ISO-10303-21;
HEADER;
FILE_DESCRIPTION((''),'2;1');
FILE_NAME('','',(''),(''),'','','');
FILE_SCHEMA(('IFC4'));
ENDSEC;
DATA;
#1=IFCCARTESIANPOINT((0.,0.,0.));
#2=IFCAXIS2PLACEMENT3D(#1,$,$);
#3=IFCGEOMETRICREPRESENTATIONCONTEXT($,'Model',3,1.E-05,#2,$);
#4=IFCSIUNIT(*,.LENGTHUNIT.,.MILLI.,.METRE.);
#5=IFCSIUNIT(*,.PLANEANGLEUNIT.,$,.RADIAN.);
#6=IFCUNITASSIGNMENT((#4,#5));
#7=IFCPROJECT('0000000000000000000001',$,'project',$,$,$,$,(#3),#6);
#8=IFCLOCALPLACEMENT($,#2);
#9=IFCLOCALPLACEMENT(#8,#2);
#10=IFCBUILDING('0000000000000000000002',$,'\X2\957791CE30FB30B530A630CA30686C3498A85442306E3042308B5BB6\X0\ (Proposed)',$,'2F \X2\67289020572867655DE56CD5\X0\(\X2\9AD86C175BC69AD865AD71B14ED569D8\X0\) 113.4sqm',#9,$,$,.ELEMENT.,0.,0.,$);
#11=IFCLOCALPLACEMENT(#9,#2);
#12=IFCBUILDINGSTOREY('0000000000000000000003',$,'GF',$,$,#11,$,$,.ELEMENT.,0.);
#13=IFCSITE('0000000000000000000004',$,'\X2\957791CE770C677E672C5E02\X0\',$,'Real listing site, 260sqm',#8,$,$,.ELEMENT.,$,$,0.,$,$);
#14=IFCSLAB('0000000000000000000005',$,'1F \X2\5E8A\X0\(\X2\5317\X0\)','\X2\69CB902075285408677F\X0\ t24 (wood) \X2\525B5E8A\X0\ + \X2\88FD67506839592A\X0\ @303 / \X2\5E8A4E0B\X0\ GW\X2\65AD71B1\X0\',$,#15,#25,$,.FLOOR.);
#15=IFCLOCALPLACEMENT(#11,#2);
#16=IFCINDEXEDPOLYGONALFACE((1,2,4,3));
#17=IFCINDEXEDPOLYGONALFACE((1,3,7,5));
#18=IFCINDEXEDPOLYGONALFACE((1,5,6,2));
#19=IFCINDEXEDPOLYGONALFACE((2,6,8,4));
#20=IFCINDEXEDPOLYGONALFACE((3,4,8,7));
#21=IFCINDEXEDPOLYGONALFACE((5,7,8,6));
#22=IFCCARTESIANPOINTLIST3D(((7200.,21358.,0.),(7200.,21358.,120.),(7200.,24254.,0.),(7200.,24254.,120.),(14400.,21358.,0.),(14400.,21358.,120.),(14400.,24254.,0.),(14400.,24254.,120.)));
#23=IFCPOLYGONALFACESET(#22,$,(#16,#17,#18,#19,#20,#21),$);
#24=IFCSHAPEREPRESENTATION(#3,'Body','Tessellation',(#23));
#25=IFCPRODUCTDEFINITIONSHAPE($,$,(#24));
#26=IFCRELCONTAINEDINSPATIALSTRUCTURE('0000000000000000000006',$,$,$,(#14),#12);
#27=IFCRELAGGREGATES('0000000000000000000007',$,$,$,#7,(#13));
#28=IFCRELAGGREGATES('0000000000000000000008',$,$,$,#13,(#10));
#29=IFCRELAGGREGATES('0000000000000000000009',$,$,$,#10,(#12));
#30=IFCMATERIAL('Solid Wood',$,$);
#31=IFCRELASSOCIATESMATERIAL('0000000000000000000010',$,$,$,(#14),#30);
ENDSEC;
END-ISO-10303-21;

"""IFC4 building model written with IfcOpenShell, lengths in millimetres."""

from ifc_helpers import new_model, si_unit, frame, frame_2d, origin, place, context, project, spatial, rectangle, extrude, material, element, save


model = new_model("IFC4")

# Units and contexts
model_context = context("Model", 3, precision=1e-05, world=origin())
ifc_project = project(units=[si_unit("LENGTHUNIT", "METRE", prefix="MILLI"), si_unit("PLANEANGLEUNIT", "RADIAN")], contexts=[model_context])

# Site, building, storey
site_placement = place(None, origin())
site = spatial("IfcSite", under=ifc_project, at=site_placement, Name="長野県松本市", ObjectType="Real listing site, 260sqm", CompositionType="ELEMENT", RefElevation=0.0)
building_placement = place(site_placement, origin())
building = spatial("IfcBuilding", under=site, at=building_placement, Name="長野・サウナと水風呂のある家 (Proposed)", ObjectType="2F 木造在来工法(高気密高断熱仕様) 113.4sqm", CompositionType="ELEMENT", ElevationOfRefHeight=0.0, ElevationOfTerrain=0.0)
storey_placement = place(building_placement, origin())
storey = spatial("IfcBuildingStorey", under=building, at=storey_placement, Name="GF", CompositionType="ELEMENT", Elevation=0.0)

# Shared definitions
ifc_material_1 = material(Name="Solid Wood")

# Slab
slab_1_placement = place(storey_placement, frame((3600.0, 10679.0, 0.0)))
element("IfcSlab", 1, at=slab_1_placement, inside=storey, material=ifc_material_1, Name="1F 床(北)", Description="構造用合板 t24 (wood) 剛床 + 製材根太 @303 / 床下 GW断熱", PredefinedType="FLOOR", context=model_context, shape_type="SweptSolid", body=[
    extrude(rectangle(XDim=7200.0, YDim=2896.0, at=frame_2d((3600.0, 1448.0))), frame((3600.0, 10679.0, 0.0)), (0.0, 0.0, 1.0), 120.0),
])

save(model, "model.ifc")
